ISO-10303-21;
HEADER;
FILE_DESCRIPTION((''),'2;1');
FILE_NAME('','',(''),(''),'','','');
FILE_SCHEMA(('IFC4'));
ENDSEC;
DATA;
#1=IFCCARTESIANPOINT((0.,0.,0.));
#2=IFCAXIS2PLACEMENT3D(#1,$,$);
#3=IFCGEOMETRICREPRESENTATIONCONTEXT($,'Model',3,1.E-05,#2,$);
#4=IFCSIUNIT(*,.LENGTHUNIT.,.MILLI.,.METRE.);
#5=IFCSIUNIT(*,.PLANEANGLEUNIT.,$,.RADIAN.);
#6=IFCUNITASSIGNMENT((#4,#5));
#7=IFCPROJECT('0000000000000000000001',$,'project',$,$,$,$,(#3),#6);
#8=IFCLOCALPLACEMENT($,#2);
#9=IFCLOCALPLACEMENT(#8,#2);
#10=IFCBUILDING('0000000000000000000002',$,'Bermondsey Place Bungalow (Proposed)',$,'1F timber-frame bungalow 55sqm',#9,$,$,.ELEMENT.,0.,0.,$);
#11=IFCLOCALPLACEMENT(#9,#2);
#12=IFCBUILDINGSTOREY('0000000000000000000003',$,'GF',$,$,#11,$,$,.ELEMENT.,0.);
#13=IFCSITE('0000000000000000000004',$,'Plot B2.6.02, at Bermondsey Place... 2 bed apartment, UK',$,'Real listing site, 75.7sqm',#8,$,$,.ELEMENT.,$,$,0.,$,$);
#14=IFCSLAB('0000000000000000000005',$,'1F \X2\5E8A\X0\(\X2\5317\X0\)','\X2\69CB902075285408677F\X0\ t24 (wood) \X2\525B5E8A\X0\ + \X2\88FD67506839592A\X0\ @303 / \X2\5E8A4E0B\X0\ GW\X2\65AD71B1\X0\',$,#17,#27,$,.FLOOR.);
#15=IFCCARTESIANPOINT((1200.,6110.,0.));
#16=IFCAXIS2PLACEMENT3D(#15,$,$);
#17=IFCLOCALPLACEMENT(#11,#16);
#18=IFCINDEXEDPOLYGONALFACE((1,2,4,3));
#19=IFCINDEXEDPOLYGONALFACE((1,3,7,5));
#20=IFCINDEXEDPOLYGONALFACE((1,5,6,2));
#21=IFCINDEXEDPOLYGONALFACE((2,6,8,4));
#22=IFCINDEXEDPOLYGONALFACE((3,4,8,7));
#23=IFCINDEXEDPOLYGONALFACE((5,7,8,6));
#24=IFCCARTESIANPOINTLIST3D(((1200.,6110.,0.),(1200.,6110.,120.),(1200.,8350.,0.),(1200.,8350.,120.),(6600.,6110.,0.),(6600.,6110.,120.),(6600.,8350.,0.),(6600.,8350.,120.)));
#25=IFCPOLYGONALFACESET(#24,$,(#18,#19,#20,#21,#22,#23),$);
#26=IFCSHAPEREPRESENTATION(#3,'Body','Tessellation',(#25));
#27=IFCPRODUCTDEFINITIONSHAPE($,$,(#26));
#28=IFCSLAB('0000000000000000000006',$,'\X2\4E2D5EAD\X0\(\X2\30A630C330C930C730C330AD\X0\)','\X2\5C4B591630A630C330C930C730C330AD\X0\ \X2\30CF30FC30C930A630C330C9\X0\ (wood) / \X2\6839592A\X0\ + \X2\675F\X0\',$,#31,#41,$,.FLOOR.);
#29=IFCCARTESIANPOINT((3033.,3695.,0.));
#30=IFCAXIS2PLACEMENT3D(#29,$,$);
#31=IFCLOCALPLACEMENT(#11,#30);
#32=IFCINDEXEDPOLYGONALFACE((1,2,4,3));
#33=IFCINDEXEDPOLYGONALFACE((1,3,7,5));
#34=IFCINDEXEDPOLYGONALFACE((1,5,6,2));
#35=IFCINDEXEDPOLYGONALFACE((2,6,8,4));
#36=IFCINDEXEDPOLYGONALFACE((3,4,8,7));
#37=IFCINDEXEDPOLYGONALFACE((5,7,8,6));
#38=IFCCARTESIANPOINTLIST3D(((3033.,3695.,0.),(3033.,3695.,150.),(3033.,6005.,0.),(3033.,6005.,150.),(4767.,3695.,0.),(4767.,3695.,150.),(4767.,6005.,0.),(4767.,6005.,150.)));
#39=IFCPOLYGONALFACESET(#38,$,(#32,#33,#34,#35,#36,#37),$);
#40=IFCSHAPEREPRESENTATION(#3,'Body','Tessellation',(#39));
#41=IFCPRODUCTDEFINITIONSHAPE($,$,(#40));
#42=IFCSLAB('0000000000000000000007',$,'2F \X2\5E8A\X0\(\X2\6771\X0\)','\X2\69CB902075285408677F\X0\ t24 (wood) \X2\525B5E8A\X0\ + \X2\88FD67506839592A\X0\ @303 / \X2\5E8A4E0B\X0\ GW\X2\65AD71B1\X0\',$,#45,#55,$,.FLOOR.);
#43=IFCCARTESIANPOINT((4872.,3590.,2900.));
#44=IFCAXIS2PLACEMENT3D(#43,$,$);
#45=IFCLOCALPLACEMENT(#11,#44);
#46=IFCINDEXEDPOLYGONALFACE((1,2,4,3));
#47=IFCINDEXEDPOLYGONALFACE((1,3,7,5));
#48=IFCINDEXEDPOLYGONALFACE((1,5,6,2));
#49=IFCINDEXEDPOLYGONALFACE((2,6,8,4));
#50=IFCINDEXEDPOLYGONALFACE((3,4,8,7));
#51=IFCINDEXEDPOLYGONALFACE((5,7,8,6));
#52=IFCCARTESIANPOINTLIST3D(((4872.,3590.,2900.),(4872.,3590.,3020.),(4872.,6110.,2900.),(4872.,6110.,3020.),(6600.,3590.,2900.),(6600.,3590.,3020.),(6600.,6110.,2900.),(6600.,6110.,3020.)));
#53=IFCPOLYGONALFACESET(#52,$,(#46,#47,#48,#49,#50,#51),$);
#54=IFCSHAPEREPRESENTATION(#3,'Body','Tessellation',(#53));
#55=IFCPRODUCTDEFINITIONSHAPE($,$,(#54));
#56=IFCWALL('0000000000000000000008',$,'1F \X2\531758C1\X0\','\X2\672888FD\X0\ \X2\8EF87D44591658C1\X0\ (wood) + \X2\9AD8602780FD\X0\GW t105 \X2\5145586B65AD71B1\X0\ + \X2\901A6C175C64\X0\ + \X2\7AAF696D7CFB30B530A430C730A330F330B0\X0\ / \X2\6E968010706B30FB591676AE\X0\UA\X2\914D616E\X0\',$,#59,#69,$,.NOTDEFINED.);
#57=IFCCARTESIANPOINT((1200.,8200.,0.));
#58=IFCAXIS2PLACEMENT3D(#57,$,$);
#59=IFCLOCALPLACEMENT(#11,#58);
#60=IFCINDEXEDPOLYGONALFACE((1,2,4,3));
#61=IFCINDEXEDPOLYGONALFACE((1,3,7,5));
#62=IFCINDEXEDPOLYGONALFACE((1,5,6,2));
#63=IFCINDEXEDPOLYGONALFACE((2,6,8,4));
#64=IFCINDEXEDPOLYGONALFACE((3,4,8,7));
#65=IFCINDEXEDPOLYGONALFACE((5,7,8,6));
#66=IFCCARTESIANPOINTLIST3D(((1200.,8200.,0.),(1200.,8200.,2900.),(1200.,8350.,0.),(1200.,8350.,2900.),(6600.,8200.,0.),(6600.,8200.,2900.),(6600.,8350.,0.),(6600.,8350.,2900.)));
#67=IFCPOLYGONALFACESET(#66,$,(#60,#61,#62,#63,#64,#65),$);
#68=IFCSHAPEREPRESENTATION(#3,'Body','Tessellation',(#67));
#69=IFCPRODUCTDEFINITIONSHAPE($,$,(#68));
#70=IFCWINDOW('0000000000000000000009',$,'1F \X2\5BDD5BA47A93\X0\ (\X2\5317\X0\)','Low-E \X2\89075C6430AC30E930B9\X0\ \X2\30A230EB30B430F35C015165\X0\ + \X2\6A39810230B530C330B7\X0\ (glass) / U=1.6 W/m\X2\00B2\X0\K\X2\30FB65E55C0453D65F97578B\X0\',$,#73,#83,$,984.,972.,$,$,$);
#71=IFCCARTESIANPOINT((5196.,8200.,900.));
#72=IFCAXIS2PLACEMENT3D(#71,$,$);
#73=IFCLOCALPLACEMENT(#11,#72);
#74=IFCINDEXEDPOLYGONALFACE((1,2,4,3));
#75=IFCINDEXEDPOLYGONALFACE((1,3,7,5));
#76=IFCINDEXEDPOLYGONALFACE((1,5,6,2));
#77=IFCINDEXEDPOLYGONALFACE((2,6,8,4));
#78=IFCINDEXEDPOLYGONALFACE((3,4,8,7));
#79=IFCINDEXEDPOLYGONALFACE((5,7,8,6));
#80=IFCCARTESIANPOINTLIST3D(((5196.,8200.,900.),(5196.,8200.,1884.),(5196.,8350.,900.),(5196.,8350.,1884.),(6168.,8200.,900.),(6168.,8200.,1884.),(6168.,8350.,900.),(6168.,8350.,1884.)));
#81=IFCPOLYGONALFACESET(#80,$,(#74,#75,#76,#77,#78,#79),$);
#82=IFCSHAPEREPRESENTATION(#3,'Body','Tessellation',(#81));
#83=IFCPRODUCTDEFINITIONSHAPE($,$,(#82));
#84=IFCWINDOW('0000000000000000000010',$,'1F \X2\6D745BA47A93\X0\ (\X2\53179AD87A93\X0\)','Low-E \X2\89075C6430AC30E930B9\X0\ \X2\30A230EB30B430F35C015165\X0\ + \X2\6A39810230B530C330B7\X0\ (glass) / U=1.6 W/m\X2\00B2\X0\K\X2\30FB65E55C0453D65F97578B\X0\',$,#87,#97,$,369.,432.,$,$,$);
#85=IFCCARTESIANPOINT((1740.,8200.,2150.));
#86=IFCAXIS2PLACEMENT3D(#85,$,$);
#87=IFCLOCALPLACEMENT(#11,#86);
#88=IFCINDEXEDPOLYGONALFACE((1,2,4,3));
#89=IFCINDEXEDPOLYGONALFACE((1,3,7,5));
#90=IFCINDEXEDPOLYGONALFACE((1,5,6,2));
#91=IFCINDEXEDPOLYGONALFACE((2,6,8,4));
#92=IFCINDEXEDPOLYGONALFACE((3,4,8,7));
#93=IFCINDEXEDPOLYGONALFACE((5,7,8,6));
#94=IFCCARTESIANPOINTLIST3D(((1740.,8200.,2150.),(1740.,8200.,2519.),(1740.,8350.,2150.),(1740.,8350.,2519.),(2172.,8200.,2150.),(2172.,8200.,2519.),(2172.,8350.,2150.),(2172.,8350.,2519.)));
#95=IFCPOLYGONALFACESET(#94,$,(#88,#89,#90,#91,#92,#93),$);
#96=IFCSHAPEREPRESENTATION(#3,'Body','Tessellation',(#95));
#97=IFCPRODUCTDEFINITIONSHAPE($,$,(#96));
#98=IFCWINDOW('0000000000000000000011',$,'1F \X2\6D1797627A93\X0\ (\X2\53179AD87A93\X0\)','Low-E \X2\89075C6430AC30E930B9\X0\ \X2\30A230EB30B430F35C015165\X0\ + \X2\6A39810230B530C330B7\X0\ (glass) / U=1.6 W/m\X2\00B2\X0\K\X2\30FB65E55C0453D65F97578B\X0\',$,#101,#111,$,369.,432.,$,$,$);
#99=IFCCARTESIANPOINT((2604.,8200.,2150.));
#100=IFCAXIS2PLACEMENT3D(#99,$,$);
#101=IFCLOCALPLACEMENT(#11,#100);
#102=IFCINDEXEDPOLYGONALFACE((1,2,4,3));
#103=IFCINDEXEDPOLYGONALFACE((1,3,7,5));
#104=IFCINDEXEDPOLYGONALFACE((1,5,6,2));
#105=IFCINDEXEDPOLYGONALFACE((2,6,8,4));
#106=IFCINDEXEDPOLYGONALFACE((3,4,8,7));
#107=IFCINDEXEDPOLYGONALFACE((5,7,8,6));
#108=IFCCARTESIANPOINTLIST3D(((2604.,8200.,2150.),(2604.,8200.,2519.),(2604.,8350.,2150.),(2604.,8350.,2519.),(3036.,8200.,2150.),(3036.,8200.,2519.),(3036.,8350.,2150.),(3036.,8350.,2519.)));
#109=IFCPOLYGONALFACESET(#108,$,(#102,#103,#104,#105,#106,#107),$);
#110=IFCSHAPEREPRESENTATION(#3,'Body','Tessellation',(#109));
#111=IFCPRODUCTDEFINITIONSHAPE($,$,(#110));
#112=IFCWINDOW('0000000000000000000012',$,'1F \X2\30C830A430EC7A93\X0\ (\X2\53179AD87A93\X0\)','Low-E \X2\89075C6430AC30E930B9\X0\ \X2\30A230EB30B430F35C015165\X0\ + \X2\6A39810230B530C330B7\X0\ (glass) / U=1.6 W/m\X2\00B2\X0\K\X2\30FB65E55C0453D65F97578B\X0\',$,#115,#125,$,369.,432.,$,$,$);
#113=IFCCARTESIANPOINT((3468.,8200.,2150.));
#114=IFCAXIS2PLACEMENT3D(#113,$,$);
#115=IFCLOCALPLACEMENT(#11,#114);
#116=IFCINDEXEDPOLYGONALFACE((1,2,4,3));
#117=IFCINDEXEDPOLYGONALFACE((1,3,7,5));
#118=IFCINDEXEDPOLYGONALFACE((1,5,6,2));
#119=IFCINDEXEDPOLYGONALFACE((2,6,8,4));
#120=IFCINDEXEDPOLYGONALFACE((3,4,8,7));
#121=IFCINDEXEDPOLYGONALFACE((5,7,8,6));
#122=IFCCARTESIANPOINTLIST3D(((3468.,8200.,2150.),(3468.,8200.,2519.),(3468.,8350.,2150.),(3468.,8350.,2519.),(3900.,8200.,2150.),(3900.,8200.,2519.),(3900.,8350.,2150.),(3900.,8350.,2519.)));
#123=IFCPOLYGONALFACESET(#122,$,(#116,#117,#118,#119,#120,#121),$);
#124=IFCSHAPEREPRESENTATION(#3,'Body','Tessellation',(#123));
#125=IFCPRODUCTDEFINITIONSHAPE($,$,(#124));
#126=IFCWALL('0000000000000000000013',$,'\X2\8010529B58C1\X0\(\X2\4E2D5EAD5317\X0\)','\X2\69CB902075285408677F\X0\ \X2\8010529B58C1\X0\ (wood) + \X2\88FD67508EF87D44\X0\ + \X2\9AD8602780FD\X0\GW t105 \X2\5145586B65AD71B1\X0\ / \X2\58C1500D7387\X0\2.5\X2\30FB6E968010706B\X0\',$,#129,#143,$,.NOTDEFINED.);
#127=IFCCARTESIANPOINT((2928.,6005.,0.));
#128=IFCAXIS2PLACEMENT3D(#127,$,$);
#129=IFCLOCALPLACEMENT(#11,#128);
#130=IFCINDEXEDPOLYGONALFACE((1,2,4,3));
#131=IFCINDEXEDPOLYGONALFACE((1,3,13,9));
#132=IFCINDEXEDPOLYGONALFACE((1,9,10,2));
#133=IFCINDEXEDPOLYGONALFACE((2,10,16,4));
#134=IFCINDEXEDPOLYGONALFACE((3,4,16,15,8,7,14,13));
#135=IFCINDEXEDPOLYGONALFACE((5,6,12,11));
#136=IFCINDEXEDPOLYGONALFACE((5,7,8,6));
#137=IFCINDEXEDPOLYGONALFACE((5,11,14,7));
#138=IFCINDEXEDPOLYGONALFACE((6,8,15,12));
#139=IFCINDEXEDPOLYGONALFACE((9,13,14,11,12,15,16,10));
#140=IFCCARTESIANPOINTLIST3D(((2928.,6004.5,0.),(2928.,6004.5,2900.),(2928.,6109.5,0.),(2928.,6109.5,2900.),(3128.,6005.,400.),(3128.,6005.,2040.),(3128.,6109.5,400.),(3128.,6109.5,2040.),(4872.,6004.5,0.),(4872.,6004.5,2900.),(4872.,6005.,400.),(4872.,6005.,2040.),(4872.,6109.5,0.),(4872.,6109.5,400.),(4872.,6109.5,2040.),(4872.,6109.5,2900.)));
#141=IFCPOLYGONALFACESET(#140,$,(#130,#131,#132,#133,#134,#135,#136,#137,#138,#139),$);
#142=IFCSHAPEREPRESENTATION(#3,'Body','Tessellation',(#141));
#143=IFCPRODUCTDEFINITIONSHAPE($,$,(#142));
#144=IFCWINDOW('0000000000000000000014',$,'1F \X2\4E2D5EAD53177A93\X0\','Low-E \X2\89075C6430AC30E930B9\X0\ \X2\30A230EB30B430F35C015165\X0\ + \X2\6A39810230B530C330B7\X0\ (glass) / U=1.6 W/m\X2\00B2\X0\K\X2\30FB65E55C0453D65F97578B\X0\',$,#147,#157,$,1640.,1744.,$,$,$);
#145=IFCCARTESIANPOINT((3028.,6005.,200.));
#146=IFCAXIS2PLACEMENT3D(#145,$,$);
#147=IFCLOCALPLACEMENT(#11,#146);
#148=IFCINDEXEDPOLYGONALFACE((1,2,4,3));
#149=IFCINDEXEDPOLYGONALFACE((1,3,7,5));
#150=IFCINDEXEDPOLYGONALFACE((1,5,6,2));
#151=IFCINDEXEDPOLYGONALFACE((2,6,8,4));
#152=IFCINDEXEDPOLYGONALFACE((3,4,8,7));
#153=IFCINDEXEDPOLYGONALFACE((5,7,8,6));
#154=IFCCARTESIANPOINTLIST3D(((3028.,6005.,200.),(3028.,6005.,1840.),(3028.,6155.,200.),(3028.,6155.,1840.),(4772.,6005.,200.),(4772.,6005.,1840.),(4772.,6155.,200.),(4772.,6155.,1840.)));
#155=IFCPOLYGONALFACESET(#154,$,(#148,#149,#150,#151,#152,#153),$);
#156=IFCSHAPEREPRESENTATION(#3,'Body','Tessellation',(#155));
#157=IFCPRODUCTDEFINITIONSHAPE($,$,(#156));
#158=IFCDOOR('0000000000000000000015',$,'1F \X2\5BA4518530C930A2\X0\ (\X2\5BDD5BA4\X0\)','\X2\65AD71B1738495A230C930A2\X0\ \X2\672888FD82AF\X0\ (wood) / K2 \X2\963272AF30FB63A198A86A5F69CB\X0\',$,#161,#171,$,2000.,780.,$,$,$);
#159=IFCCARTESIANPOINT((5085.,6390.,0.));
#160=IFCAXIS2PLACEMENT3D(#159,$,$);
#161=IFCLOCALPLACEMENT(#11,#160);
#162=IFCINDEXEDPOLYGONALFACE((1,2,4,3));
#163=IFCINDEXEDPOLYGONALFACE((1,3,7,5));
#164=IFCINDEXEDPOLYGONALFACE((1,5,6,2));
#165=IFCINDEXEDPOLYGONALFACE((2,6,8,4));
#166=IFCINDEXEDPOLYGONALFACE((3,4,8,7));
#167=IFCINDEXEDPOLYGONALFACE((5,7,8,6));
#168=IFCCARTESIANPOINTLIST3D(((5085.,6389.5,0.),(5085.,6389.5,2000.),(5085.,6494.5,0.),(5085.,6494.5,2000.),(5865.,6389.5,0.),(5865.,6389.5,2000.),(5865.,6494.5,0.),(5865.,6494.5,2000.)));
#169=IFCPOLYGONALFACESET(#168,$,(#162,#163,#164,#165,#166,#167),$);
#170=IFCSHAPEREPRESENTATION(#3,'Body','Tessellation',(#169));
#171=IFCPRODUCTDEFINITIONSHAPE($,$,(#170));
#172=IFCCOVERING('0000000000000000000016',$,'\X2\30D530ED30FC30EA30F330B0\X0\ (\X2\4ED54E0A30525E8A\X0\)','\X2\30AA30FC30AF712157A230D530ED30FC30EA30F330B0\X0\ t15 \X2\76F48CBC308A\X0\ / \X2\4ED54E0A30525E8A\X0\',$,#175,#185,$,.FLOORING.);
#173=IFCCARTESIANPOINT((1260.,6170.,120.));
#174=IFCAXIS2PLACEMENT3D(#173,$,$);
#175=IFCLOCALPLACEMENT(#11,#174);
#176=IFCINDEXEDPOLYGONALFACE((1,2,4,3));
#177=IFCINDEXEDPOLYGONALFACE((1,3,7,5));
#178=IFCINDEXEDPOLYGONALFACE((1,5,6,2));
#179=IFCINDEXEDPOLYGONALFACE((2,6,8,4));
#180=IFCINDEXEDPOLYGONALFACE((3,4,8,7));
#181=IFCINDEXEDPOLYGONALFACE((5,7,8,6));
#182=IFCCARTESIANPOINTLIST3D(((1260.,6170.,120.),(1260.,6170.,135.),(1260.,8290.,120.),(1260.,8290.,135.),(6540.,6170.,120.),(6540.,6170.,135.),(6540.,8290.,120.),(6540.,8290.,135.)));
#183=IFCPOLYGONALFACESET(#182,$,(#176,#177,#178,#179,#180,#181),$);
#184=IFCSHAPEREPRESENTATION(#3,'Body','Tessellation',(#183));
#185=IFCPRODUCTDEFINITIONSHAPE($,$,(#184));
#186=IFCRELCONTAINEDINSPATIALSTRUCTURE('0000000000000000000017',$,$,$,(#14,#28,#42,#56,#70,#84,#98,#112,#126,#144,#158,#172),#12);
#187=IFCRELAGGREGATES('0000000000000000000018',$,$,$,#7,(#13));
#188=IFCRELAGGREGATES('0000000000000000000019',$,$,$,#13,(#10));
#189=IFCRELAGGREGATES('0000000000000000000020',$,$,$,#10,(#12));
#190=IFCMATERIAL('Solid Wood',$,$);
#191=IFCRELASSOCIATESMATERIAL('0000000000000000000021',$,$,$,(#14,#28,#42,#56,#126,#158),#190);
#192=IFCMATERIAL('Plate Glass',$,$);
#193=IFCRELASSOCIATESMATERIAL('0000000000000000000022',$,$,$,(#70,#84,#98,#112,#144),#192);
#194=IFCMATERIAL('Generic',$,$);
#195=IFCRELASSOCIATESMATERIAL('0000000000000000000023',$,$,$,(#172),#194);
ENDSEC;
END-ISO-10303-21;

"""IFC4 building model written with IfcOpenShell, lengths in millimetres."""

from ifc_helpers import new_model, si_unit, frame, frame_2d, origin, place, context, project, spatial, rectangle, extrude, material, element, fill, save


model = new_model("IFC4")

# Units and contexts
model_context = context("Model", 3, precision=1e-05, world=origin())
ifc_project = project(units=[si_unit("LENGTHUNIT", "METRE", prefix="MILLI"), si_unit("PLANEANGLEUNIT", "RADIAN")], contexts=[model_context])

# Site, building, storey
site_placement = place(None, origin())
site = spatial("IfcSite", under=ifc_project, at=site_placement, Name="Plot B2.6.02, at Bermondsey Place... 2 bed apartment, UK", ObjectType="Real listing site, 75.7sqm", CompositionType="ELEMENT", RefElevation=0.0)
building_placement = place(site_placement, origin())
building = spatial("IfcBuilding", under=site, at=building_placement, Name="Bermondsey Place Bungalow (Proposed)", ObjectType="1F timber-frame bungalow 55sqm", CompositionType="ELEMENT", ElevationOfRefHeight=0.0, ElevationOfTerrain=0.0)
storey_placement = place(building_placement, origin())
storey = spatial("IfcBuildingStorey", under=building, at=storey_placement, Name="GF", CompositionType="ELEMENT", Elevation=0.0)

# Slabs
ifc_material_1 = material(Name="Solid Wood")
slab_1_placement = place(storey_placement, frame((1200.0, 6110.0, 0.0)))
element("IfcSlab", 1, at=slab_1_placement, inside=storey, material=ifc_material_1, Name="1F 床(北)", Description="構造用合板 t24 (wood) 剛床 + 製材根太 @303 / 床下 GW断熱", PredefinedType="FLOOR", context=model_context, shape_type="SweptSolid", body=[
    extrude(rectangle(XDim=5400.0, YDim=2240.0, at=frame_2d((2700.0, 1120.0))), frame((1200.0, 6110.0, 0.0)), (0.0, 0.0, 1.0), 120.0),
])
slab_2_placement = place(storey_placement, frame((3033.0, 3695.0, 0.0)))
element("IfcSlab", 2, at=slab_2_placement, inside=storey, material=ifc_material_1, Name="中庭(ウッドデッキ)", Description="屋外ウッドデッキ ハードウッド (wood) / 根太 + 束", PredefinedType="FLOOR", context=model_context, shape_type="SweptSolid", body=[
    extrude(rectangle(XDim=1734.0, YDim=2310.0, at=frame_2d((867.0, 1155.0))), frame((3033.0, 3695.0, 0.0)), (0.0, 0.0, 1.0), 150.0),
])
slab_3_placement = place(storey_placement, frame((4872.0, 3590.0, 2900.0)))
element("IfcSlab", 3, at=slab_3_placement, inside=storey, material=ifc_material_1, Name="2F 床(東)", Description="構造用合板 t24 (wood) 剛床 + 製材根太 @303 / 床下 GW断熱", PredefinedType="FLOOR", context=model_context, shape_type="SweptSolid", body=[
    extrude(rectangle(XDim=1728.0, YDim=2520.0, at=frame_2d((864.0, 1260.0))), frame((4872.0, 3590.0, 2900.0)), (0.0, 0.0, 1.0), 120.0),
])

# Wall, openings, windows
wall_1_placement = place(storey_placement, frame((1200.0, 8200.0, 0.0)))
wall_1 = element("IfcWall", 4, at=wall_1_placement, inside=storey, material=ifc_material_1, Name="1F 北壁", Description="木製 軸組外壁 (wood) + 高性能GW t105 充填断熱 + 通気層 + 窯業系サイディング / 準耐火・外皮UA配慮", PredefinedType="NOTDEFINED", context=model_context, shape_type="SweptSolid", body=[
    extrude(rectangle(XDim=5400.0, YDim=150.0, at=frame_2d((2700.0, 75.0))), frame((1200.0, 8200.0, 0.0)), (0.0, 0.0, 1.0), 2900.0),
])
opening_1_placement = place(storey_placement, frame((5196.0, 8200.0, 900.0)))
opening_1 = element("IfcOpeningElement", 5, at=opening_1_placement, cuts=wall_1, PredefinedType="NOTDEFINED", context=model_context, shape_type="SweptSolid", body=[
    extrude(rectangle(XDim=972.0, YDim=150.0, at=frame_2d((486.0, 75.0))), frame((5196.0, 8200.0, 900.0)), (0.0, 0.0, 1.0), 984.0),
])
opening_2_placement = place(storey_placement, frame((1740.0, 8200.0, 2150.0)))
opening_2 = element("IfcOpeningElement", 6, at=opening_2_placement, cuts=wall_1, PredefinedType="NOTDEFINED", context=model_context, shape_type="SweptSolid", body=[
    extrude(rectangle(XDim=432.0, YDim=150.0, at=frame_2d((216.0, 75.0))), frame((1740.0, 8200.0, 2150.0)), (0.0, 0.0, 1.0), 369.0),
])
opening_3_placement = place(storey_placement, frame((2604.0, 8200.0, 2150.0)))
opening_3 = element("IfcOpeningElement", 7, at=opening_3_placement, cuts=wall_1, PredefinedType="NOTDEFINED", context=model_context, shape_type="SweptSolid", body=[
    extrude(rectangle(XDim=432.0, YDim=150.0, at=frame_2d((216.0, 75.0))), frame((2604.0, 8200.0, 2150.0)), (0.0, 0.0, 1.0), 369.0),
])
opening_4_placement = place(storey_placement, frame((3468.0, 8200.0, 2150.0)))
opening_4 = element("IfcOpeningElement", 8, at=opening_4_placement, cuts=wall_1, PredefinedType="NOTDEFINED", context=model_context, shape_type="SweptSolid", body=[
    extrude(rectangle(XDim=432.0, YDim=150.0, at=frame_2d((216.0, 75.0))), frame((3468.0, 8200.0, 2150.0)), (0.0, 0.0, 1.0), 369.0),
])
ifc_material_2 = material(Name="Plate Glass")
window_1_placement = place(storey_placement, frame((5196.0, 8200.0, 900.0)))
window_1 = element("IfcWindow", 9, at=window_1_placement, inside=storey, material=ifc_material_2, Name="1F 寝室窓 (北)", Description="Low-E 複層ガラス アルゴン封入 + 樹脂サッシ (glass) / U=1.6 W/m²K・日射取得型", OverallHeight=984.0, OverallWidth=972.0, context=model_context, shape_type="SweptSolid", body=[
    extrude(rectangle(XDim=972.0, YDim=150.0, at=frame_2d((486.0, 75.0))), frame((5196.0, 8200.0, 900.0)), (0.0, 0.0, 1.0), 984.0),
])
fill(opening_1, window_1)
window_2_placement = place(storey_placement, frame((1740.0, 8200.0, 2150.0)))
window_2 = element("IfcWindow", 10, at=window_2_placement, inside=storey, material=ifc_material_2, Name="1F 浴室窓 (北高窓)", Description="Low-E 複層ガラス アルゴン封入 + 樹脂サッシ (glass) / U=1.6 W/m²K・日射取得型", OverallHeight=369.0, OverallWidth=432.0, context=model_context, shape_type="SweptSolid", body=[
    extrude(rectangle(XDim=432.0, YDim=150.0, at=frame_2d((216.0, 75.0))), frame((1740.0, 8200.0, 2150.0)), (0.0, 0.0, 1.0), 369.0),
])
fill(opening_2, window_2)
window_3_placement = place(storey_placement, frame((2604.0, 8200.0, 2150.0)))
window_3 = element("IfcWindow", 11, at=window_3_placement, inside=storey, material=ifc_material_2, Name="1F 洗面窓 (北高窓)", Description="Low-E 複層ガラス アルゴン封入 + 樹脂サッシ (glass) / U=1.6 W/m²K・日射取得型", OverallHeight=369.0, OverallWidth=432.0, context=model_context, shape_type="SweptSolid", body=[
    extrude(rectangle(XDim=432.0, YDim=150.0, at=frame_2d((216.0, 75.0))), frame((2604.0, 8200.0, 2150.0)), (0.0, 0.0, 1.0), 369.0),
])
fill(opening_3, window_3)
window_4_placement = place(storey_placement, frame((3468.0, 8200.0, 2150.0)))
window_4 = element("IfcWindow", 12, at=window_4_placement, inside=storey, material=ifc_material_2, Name="1F トイレ窓 (北高窓)", Description="Low-E 複層ガラス アルゴン封入 + 樹脂サッシ (glass) / U=1.6 W/m²K・日射取得型", OverallHeight=369.0, OverallWidth=432.0, context=model_context, shape_type="SweptSolid", body=[
    extrude(rectangle(XDim=432.0, YDim=150.0, at=frame_2d((216.0, 75.0))), frame((3468.0, 8200.0, 2150.0)), (0.0, 0.0, 1.0), 369.0),
])
fill(opening_4, window_4)

# Wall, opening, window
wall_2_placement = place(storey_placement, frame((2928.0, 6005.0, 0.0)))
wall_2 = element("IfcWall", 13, at=wall_2_placement, inside=storey, material=ifc_material_1, Name="耐力壁(中庭北)", Description="構造用合板 耐力壁 (wood) + 製材軸組 + 高性能GW t105 充填断熱 / 壁倍率2.5・準耐火", PredefinedType="NOTDEFINED", context=model_context, shape_type="SweptSolid", body=[
    extrude(rectangle(XDim=1944.0, YDim=105.0, at=frame_2d((972.0, 52.0))), frame((2928.0, 6005.0, 0.0)), (0.0, 0.0, 1.0), 2900.0),
])
opening_5_placement = place(storey_placement, frame((3028.0, 6005.0, 200.0)))
opening_5 = element("IfcOpeningElement", 14, at=opening_5_placement, cuts=wall_2, PredefinedType="NOTDEFINED", context=model_context, shape_type="SweptSolid", body=[
    extrude(rectangle(XDim=1744.0, YDim=150.0, at=frame_2d((872.0, 75.0))), frame((3028.0, 6005.0, 200.0)), (0.0, 0.0, 1.0), 1640.0),
])
window_5_placement = place(storey_placement, frame((3028.0, 6005.0, 200.0)))
window_5 = element("IfcWindow", 15, at=window_5_placement, inside=storey, material=ifc_material_2, Name="1F 中庭北窓", Description="Low-E 複層ガラス アルゴン封入 + 樹脂サッシ (glass) / U=1.6 W/m²K・日射取得型", OverallHeight=1640.0, OverallWidth=1744.0, context=model_context, shape_type="SweptSolid", body=[
    extrude(rectangle(XDim=1744.0, YDim=150.0, at=frame_2d((872.0, 75.0))), frame((3028.0, 6005.0, 200.0)), (0.0, 0.0, 1.0), 1640.0),
])
fill(opening_5, window_5)

# Door
door_1_placement = place(storey_placement, frame((5085.0, 6390.0, 0.0)))
element("IfcDoor", 16, at=door_1_placement, inside=storey, material=ifc_material_1, Name="1F 室内ドア (寝室)", Description="断熱玄関ドア 木製芯 (wood) / K2 防犯・採風機構", OverallHeight=2000.0, OverallWidth=780.0, context=model_context, shape_type="SweptSolid", body=[
    extrude(rectangle(XDim=780.0, YDim=105.0, at=frame_2d((390.0, 52.0))), frame((5085.0, 6390.0, 0.0)), (0.0, 0.0, 1.0), 2000.0),
])

# Covering
ifc_material_3 = material(Name="Generic")
covering_1_placement = place(storey_placement, frame((1260.0, 6170.0, 120.0)))
element("IfcCovering", 17, at=covering_1_placement, inside=storey, material=ifc_material_3, Name="フローリング (仕上げ床)", Description="オーク無垢フローリング t15 直貼り / 仕上げ床", PredefinedType="FLOORING", context=model_context, shape_type="SweptSolid", body=[
    extrude(rectangle(XDim=5280.0, YDim=2120.0, at=frame_2d((2640.0, 1060.0))), frame((1260.0, 6170.0, 120.0)), (0.0, 0.0, 1.0), 15.0),
])

save(model, "model.ifc")
